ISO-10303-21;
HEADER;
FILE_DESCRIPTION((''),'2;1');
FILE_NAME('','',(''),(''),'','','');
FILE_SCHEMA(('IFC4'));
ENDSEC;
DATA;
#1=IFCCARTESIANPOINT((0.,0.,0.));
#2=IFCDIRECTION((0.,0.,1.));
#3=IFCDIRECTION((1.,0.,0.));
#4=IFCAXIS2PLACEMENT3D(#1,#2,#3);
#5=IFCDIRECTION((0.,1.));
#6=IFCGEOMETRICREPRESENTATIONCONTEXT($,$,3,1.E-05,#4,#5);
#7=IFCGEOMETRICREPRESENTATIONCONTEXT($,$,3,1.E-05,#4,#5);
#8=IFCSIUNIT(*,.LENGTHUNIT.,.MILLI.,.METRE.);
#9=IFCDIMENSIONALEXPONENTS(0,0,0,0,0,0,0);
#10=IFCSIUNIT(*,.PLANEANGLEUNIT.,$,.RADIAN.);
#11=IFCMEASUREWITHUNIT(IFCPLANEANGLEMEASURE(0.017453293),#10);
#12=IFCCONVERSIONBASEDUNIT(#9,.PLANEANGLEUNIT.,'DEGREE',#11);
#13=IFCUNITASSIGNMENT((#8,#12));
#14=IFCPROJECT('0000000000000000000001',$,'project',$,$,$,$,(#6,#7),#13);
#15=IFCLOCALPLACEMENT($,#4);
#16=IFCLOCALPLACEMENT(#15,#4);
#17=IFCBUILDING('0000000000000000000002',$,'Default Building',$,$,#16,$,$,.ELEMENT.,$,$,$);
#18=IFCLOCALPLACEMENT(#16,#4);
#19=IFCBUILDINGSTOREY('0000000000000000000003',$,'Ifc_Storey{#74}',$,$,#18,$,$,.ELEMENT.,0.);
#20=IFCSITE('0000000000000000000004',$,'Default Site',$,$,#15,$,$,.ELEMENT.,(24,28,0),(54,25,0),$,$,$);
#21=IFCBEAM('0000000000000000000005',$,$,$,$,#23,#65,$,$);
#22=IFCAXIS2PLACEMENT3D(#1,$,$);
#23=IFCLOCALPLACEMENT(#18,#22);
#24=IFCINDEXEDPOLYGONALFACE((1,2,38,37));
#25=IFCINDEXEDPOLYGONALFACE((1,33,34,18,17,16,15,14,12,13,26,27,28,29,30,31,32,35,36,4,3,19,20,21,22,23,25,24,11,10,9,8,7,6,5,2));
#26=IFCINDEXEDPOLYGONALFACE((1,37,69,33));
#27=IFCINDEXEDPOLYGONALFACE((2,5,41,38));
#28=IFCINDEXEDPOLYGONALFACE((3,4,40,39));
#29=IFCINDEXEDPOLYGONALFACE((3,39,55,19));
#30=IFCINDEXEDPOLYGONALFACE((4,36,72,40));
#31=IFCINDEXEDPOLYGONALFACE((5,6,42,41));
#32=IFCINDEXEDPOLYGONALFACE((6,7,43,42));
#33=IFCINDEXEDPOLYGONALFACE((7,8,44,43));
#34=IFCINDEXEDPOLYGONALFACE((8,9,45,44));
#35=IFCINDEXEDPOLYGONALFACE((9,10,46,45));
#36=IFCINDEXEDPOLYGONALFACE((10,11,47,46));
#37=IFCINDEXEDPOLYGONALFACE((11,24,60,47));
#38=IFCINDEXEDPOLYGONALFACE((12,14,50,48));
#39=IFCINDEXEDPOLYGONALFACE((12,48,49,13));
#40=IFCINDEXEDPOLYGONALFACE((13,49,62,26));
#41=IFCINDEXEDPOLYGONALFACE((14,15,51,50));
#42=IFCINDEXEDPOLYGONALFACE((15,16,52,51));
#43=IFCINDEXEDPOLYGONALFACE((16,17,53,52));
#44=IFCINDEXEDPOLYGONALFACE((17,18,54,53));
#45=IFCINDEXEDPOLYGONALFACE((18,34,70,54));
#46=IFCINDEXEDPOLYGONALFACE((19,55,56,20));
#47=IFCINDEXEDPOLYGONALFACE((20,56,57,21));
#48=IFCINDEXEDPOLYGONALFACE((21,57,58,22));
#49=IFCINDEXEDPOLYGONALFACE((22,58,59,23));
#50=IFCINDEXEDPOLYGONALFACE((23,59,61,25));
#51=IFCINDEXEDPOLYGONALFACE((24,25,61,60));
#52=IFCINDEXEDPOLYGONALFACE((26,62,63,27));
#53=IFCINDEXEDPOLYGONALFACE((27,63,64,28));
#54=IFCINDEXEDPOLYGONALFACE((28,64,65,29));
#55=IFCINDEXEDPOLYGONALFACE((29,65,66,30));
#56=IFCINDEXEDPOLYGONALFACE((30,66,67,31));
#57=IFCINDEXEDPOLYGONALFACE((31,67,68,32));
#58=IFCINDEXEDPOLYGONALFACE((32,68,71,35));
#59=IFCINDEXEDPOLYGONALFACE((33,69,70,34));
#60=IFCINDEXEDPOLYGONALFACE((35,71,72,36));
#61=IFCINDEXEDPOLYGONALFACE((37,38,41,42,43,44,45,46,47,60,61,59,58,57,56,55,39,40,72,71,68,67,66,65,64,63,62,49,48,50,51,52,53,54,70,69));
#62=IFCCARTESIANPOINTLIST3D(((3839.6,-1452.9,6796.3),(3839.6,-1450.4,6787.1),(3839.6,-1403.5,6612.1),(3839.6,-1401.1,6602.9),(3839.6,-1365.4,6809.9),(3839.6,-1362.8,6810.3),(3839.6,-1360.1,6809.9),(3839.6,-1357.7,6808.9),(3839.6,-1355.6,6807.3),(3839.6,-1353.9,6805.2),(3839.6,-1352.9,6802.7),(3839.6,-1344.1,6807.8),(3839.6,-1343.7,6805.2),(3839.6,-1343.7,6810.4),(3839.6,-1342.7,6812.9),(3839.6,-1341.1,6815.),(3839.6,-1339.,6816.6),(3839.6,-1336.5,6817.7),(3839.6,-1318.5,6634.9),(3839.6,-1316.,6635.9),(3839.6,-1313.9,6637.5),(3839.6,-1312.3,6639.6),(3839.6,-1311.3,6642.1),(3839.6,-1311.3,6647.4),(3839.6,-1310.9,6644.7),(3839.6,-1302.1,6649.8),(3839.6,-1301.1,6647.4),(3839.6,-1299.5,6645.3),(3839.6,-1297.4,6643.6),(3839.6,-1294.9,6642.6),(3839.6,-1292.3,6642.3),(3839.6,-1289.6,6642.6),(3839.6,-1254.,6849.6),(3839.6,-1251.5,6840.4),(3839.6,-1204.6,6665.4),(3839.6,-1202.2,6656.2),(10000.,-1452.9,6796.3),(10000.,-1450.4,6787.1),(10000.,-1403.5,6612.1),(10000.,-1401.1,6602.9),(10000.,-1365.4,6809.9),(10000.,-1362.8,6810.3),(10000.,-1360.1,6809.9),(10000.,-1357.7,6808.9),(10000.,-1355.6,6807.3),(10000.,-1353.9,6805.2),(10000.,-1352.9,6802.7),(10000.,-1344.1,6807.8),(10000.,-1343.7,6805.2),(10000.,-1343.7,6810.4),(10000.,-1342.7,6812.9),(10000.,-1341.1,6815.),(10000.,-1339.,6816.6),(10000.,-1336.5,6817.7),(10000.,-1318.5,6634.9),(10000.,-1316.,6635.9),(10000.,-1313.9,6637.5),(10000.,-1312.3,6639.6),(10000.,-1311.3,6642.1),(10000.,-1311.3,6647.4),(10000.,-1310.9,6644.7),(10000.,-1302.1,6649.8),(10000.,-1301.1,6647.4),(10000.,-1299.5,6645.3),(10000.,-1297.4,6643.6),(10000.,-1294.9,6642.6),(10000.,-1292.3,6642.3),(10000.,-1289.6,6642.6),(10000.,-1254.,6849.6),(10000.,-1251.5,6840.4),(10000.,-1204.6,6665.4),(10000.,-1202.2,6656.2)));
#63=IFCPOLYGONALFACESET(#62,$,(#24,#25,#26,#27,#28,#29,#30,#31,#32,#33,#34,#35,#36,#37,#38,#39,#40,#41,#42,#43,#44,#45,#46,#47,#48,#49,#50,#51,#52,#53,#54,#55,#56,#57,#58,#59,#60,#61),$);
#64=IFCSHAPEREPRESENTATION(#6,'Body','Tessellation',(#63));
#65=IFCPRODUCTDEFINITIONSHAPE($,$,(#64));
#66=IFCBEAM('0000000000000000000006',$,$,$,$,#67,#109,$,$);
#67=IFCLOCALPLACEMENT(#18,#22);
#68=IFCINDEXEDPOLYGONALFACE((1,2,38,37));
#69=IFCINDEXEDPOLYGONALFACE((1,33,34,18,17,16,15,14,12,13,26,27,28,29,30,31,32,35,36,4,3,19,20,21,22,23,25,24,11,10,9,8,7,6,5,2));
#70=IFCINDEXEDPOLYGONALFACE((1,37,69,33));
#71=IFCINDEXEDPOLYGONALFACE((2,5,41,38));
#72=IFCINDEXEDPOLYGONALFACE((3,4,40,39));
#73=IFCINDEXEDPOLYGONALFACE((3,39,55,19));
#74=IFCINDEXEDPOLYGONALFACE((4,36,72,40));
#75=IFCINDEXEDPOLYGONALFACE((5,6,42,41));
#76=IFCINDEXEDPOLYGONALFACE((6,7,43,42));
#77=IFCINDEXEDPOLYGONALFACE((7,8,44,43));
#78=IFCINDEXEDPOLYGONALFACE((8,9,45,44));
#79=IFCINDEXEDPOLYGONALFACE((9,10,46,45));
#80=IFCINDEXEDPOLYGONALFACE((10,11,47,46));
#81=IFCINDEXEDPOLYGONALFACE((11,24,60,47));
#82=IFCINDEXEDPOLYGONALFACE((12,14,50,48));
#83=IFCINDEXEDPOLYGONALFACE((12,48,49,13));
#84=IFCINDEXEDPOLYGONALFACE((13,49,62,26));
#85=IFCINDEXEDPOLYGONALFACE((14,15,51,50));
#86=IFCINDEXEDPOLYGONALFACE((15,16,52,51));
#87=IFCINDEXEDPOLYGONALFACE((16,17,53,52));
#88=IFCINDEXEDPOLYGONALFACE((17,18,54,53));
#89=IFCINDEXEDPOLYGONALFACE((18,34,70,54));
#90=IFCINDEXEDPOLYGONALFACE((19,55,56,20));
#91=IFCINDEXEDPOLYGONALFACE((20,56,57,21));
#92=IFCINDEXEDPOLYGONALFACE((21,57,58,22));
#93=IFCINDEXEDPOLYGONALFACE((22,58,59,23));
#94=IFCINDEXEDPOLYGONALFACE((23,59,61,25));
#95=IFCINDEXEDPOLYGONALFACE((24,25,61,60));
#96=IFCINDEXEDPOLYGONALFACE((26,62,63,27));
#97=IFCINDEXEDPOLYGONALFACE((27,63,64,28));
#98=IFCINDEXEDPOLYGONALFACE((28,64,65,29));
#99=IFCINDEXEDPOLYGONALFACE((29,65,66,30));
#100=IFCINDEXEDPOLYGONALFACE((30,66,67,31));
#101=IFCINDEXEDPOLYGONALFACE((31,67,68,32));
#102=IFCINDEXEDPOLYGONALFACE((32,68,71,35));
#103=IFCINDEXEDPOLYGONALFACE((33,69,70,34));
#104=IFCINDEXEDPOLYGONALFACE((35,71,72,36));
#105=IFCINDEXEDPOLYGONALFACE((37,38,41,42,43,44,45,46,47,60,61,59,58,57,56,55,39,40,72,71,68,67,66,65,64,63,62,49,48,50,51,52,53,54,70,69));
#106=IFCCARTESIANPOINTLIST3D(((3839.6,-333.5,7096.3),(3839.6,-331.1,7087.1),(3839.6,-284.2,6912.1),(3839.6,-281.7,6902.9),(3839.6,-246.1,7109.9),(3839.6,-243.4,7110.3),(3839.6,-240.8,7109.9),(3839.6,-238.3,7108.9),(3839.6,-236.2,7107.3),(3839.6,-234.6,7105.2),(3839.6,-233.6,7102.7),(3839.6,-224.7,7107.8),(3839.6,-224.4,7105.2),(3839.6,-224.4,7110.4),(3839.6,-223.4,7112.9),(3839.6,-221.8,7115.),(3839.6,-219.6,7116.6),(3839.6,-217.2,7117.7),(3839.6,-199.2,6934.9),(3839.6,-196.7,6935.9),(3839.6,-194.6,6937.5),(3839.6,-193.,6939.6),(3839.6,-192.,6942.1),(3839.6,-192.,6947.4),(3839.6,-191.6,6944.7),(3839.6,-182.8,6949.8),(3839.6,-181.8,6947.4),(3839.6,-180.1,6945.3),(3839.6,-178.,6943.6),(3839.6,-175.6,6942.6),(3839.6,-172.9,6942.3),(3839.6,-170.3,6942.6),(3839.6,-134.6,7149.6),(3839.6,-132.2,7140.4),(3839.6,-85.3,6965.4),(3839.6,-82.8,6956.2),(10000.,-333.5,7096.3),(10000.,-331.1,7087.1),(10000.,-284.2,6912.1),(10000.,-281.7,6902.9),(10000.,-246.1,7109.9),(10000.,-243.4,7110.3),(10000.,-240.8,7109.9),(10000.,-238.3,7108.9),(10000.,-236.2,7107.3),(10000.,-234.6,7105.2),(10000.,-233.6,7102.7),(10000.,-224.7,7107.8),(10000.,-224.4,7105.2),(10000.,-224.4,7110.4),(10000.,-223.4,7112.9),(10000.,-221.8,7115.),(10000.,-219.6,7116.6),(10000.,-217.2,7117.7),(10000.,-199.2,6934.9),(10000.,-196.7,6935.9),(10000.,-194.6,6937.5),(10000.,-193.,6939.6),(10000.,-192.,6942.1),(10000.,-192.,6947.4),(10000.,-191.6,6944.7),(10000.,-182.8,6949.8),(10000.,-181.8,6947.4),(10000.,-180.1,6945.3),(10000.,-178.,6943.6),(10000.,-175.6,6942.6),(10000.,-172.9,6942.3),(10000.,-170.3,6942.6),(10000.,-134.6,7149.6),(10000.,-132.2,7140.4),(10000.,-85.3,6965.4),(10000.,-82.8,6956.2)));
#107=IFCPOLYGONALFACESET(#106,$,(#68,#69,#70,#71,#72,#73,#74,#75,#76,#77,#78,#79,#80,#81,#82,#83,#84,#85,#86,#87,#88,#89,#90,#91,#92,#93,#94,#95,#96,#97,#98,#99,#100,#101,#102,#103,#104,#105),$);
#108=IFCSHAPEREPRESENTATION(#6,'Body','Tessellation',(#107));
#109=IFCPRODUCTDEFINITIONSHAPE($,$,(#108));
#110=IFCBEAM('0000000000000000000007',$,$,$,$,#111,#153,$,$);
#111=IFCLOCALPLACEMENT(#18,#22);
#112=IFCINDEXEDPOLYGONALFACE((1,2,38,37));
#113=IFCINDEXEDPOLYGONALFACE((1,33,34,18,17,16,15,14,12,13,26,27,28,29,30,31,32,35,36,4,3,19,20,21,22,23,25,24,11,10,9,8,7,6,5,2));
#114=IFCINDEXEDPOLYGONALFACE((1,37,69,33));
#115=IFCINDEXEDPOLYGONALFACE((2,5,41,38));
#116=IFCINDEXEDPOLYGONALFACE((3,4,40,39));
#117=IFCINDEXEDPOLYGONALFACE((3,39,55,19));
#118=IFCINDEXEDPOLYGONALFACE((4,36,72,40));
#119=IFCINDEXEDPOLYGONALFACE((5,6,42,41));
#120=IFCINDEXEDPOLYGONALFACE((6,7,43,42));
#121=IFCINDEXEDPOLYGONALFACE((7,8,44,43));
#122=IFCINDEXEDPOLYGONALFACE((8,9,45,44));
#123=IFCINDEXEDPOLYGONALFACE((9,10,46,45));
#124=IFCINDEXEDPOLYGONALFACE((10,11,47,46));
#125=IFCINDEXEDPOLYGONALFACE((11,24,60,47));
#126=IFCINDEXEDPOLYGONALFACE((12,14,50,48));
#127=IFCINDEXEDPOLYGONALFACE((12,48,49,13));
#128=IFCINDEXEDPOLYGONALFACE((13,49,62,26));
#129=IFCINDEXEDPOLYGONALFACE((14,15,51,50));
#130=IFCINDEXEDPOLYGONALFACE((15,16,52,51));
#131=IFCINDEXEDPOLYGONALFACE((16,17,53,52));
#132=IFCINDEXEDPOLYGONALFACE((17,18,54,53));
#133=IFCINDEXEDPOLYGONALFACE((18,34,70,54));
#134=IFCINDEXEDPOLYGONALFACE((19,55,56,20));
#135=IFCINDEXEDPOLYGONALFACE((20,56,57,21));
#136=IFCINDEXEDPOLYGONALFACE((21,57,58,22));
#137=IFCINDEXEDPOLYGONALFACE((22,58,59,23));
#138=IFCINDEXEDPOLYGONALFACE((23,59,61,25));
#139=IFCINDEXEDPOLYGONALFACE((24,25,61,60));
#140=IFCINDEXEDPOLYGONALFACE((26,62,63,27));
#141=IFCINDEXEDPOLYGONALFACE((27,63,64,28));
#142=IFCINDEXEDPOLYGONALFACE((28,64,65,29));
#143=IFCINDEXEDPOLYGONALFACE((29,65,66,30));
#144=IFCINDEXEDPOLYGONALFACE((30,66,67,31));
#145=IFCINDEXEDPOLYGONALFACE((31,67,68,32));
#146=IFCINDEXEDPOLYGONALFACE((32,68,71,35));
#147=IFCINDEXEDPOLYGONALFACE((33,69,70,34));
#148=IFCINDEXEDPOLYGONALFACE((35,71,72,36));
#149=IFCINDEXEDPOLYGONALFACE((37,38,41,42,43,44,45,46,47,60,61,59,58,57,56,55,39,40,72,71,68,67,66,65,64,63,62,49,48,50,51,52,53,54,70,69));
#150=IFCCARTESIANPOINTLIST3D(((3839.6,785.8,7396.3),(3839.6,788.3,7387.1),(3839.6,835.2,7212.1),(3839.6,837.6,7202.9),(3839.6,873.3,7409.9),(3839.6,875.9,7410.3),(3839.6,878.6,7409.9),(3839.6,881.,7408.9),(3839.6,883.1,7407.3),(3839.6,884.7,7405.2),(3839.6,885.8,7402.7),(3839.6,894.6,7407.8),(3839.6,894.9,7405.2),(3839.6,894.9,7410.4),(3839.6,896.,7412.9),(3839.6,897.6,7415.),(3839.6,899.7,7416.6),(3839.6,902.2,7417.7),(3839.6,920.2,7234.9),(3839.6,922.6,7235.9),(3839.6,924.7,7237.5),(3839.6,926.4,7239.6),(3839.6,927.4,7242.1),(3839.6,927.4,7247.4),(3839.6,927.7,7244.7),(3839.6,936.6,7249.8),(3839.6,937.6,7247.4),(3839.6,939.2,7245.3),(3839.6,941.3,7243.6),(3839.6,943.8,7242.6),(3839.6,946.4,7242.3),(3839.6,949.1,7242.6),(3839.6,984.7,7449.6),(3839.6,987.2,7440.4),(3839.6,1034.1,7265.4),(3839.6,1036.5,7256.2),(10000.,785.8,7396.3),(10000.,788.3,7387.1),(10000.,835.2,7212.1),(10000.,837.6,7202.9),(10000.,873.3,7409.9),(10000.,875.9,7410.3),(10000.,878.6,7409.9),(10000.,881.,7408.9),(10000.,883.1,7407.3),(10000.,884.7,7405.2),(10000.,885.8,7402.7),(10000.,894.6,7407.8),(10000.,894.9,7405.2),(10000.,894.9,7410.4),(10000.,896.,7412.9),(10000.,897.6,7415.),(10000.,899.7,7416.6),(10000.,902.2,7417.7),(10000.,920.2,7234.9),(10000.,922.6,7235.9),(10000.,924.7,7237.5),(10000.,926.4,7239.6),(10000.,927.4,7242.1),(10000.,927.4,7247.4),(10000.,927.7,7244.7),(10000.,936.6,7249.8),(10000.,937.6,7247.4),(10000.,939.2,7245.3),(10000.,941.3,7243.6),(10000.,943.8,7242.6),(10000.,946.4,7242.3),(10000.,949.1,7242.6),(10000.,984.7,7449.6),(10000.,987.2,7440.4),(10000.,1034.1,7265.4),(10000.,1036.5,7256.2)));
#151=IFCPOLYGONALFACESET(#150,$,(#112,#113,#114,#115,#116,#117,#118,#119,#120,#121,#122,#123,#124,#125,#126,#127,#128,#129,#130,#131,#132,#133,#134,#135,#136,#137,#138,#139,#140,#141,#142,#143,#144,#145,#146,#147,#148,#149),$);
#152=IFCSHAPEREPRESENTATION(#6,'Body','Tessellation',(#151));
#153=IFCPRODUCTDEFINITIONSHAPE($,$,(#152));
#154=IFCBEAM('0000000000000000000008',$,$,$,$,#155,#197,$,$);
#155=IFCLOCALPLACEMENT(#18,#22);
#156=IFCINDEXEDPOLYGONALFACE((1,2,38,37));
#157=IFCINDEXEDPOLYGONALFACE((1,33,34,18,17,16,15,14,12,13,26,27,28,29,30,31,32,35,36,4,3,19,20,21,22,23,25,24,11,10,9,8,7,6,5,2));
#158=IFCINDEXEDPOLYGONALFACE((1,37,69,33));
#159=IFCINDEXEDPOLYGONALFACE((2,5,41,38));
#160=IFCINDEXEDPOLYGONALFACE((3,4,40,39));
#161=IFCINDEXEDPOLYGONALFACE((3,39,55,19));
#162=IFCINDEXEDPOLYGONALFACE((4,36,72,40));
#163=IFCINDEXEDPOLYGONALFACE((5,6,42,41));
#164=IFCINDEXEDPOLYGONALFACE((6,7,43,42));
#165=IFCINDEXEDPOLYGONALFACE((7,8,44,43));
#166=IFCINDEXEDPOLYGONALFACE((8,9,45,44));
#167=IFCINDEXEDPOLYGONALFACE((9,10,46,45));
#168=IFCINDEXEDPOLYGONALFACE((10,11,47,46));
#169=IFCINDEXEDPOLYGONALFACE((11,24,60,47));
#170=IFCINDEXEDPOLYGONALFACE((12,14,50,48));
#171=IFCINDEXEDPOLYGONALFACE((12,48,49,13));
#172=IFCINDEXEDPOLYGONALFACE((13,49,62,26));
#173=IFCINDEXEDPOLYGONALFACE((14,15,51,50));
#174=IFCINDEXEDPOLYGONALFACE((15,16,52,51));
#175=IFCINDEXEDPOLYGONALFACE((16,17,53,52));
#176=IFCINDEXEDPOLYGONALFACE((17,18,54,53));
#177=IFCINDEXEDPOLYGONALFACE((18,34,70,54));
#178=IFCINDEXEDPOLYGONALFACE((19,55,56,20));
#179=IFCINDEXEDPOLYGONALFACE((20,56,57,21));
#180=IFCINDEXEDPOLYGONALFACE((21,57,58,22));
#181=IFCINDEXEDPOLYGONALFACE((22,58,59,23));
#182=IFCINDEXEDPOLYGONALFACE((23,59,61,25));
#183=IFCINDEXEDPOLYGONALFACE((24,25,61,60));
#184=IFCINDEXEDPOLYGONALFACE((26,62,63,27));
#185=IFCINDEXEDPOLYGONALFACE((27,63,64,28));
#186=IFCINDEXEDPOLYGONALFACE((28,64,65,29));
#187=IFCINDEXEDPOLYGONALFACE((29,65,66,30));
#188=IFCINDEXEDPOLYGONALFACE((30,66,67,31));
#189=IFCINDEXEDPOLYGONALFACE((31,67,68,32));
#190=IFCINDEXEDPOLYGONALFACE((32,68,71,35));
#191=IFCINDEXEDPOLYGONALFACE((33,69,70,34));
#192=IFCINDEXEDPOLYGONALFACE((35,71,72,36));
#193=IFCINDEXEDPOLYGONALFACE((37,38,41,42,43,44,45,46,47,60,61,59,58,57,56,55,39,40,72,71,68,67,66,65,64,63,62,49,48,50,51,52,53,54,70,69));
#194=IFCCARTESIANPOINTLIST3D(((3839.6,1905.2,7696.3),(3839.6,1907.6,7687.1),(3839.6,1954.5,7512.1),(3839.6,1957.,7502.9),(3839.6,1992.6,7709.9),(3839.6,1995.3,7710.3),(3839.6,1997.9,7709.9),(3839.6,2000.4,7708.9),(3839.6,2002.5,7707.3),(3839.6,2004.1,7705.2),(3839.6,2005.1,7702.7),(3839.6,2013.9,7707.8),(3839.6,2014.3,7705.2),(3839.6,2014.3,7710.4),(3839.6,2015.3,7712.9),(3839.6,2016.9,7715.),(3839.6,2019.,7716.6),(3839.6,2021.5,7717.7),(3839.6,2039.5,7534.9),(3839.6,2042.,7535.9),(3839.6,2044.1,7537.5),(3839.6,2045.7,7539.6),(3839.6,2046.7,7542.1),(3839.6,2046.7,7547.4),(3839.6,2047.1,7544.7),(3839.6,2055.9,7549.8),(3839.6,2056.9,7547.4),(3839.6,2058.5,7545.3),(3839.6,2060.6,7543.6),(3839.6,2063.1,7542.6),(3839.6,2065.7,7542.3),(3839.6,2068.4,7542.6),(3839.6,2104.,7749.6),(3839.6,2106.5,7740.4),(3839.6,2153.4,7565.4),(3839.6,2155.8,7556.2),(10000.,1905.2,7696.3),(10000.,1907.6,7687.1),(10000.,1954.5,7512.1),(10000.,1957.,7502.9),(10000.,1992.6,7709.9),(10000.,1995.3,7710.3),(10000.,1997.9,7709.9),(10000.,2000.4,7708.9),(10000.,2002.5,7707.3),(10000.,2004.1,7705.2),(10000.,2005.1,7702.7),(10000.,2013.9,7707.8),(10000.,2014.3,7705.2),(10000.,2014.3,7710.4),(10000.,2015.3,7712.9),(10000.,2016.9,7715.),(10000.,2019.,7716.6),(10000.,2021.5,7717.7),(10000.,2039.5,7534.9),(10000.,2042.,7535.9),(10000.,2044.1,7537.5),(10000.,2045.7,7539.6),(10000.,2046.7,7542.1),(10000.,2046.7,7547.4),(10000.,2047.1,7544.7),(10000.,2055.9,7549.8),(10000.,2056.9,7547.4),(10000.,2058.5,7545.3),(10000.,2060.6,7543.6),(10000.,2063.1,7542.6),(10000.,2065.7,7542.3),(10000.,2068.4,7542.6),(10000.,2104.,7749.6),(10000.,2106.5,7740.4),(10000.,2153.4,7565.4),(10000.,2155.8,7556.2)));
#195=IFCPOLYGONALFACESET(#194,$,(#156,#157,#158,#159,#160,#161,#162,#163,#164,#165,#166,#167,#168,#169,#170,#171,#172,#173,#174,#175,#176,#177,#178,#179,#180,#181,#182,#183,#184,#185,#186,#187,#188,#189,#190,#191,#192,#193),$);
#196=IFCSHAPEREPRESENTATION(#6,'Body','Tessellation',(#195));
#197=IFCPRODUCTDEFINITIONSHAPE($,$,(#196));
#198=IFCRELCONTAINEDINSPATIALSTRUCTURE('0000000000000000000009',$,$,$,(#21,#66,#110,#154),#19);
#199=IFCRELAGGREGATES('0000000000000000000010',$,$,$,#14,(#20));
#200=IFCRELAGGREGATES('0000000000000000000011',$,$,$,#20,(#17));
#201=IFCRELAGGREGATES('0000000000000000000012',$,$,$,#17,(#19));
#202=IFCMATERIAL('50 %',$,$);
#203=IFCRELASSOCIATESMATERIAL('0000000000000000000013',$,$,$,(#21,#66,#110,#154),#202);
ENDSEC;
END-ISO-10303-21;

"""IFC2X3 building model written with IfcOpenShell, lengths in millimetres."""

from ifc_helpers import new_model, entity, si_unit, converted_unit, direction, frame, origin_with_axes, origin_2d_with_axis, place, context, project, spatial, i_section, extrude, material, element, save


model = new_model("IFC2X3")

# Units and contexts
context_of_model_1 = context(None, 3, precision=1e-05, world=origin_with_axes(), true_north=direction((0.0, 1.0)))
context_of_model_2 = context(None, 3, precision=1e-05, world=origin_with_axes(), true_north=direction((0.0, 1.0)))
ifc_project = project(units=[si_unit("LENGTHUNIT", "METRE", prefix="MILLI"), converted_unit("PLANEANGLEUNIT", "DEGREE", entity("IfcPlaneAngleMeasure", 0.017453293), si_unit("PLANEANGLEUNIT", "RADIAN"), dimensions=[0, 0, 0, 0, 0, 0, 0])], contexts=[context_of_model_1, context_of_model_2])

# Site, building, storey
site_placement = place(None, origin_with_axes())
site = spatial("IfcSite", under=ifc_project, at=site_placement, Name="Default Site", CompositionType="ELEMENT", RefLatitude=(24, 28, 0), RefLongitude=(54, 25, 0))
building_placement = place(site_placement, origin_with_axes())
building = spatial("IfcBuilding", under=site, at=building_placement, Name="Default Building", CompositionType="ELEMENT")
storey_placement = place(building_placement, origin_with_axes())
storey = spatial("IfcBuildingStorey", under=building, at=storey_placement, Name="Ifc_Storey{#74}", CompositionType="ELEMENT", Elevation=0.0)

# Shared definitions
ifc_material_1 = material(Name="50 %")

# Beams
for number, where, z_axis, x_axis in (
    (1, (3839.6, -1327.5, 6726.3), (0.0, -0.258819, 0.965926), (-1.0, 0.0, 0.0)),
    (2, (3839.6, -208.2, 7026.3), (0.0, -0.258819, 0.965926), (-1.0, 0.0, 0.0)),
    (3, (3839.6, 911.2, 7326.3), (0.0, -0.258819, 0.965926), (-1.0, 0.0, 0.0)),
    (4, (3839.6, 2030.5, 7626.3), (0.0, -0.258819, 0.965926), (-1.0, 0.0, 0.0)),
):
    element("IfcBeam", number, at=place(storey_placement, frame(where, z_axis=z_axis, x_axis=x_axis)), inside=storey, material=ifc_material_1, context=context_of_model_1, shape_type="SweptSolid", body=[
        extrude(i_section(OverallWidth=205.9, OverallDepth=200.2, WebThickness=9.5, FlangeThickness=9.5, FilletRadius=10.2, at=origin_2d_with_axis()), frame((0.0, 0.0, 0.0), z_axis=(-1.0, 0.0, 0.0), x_axis=(0.0, 1.0, 0.0)), (0.0, 0.0, 1.0), 6160.4),
    ])

save(model, "model.ifc")
